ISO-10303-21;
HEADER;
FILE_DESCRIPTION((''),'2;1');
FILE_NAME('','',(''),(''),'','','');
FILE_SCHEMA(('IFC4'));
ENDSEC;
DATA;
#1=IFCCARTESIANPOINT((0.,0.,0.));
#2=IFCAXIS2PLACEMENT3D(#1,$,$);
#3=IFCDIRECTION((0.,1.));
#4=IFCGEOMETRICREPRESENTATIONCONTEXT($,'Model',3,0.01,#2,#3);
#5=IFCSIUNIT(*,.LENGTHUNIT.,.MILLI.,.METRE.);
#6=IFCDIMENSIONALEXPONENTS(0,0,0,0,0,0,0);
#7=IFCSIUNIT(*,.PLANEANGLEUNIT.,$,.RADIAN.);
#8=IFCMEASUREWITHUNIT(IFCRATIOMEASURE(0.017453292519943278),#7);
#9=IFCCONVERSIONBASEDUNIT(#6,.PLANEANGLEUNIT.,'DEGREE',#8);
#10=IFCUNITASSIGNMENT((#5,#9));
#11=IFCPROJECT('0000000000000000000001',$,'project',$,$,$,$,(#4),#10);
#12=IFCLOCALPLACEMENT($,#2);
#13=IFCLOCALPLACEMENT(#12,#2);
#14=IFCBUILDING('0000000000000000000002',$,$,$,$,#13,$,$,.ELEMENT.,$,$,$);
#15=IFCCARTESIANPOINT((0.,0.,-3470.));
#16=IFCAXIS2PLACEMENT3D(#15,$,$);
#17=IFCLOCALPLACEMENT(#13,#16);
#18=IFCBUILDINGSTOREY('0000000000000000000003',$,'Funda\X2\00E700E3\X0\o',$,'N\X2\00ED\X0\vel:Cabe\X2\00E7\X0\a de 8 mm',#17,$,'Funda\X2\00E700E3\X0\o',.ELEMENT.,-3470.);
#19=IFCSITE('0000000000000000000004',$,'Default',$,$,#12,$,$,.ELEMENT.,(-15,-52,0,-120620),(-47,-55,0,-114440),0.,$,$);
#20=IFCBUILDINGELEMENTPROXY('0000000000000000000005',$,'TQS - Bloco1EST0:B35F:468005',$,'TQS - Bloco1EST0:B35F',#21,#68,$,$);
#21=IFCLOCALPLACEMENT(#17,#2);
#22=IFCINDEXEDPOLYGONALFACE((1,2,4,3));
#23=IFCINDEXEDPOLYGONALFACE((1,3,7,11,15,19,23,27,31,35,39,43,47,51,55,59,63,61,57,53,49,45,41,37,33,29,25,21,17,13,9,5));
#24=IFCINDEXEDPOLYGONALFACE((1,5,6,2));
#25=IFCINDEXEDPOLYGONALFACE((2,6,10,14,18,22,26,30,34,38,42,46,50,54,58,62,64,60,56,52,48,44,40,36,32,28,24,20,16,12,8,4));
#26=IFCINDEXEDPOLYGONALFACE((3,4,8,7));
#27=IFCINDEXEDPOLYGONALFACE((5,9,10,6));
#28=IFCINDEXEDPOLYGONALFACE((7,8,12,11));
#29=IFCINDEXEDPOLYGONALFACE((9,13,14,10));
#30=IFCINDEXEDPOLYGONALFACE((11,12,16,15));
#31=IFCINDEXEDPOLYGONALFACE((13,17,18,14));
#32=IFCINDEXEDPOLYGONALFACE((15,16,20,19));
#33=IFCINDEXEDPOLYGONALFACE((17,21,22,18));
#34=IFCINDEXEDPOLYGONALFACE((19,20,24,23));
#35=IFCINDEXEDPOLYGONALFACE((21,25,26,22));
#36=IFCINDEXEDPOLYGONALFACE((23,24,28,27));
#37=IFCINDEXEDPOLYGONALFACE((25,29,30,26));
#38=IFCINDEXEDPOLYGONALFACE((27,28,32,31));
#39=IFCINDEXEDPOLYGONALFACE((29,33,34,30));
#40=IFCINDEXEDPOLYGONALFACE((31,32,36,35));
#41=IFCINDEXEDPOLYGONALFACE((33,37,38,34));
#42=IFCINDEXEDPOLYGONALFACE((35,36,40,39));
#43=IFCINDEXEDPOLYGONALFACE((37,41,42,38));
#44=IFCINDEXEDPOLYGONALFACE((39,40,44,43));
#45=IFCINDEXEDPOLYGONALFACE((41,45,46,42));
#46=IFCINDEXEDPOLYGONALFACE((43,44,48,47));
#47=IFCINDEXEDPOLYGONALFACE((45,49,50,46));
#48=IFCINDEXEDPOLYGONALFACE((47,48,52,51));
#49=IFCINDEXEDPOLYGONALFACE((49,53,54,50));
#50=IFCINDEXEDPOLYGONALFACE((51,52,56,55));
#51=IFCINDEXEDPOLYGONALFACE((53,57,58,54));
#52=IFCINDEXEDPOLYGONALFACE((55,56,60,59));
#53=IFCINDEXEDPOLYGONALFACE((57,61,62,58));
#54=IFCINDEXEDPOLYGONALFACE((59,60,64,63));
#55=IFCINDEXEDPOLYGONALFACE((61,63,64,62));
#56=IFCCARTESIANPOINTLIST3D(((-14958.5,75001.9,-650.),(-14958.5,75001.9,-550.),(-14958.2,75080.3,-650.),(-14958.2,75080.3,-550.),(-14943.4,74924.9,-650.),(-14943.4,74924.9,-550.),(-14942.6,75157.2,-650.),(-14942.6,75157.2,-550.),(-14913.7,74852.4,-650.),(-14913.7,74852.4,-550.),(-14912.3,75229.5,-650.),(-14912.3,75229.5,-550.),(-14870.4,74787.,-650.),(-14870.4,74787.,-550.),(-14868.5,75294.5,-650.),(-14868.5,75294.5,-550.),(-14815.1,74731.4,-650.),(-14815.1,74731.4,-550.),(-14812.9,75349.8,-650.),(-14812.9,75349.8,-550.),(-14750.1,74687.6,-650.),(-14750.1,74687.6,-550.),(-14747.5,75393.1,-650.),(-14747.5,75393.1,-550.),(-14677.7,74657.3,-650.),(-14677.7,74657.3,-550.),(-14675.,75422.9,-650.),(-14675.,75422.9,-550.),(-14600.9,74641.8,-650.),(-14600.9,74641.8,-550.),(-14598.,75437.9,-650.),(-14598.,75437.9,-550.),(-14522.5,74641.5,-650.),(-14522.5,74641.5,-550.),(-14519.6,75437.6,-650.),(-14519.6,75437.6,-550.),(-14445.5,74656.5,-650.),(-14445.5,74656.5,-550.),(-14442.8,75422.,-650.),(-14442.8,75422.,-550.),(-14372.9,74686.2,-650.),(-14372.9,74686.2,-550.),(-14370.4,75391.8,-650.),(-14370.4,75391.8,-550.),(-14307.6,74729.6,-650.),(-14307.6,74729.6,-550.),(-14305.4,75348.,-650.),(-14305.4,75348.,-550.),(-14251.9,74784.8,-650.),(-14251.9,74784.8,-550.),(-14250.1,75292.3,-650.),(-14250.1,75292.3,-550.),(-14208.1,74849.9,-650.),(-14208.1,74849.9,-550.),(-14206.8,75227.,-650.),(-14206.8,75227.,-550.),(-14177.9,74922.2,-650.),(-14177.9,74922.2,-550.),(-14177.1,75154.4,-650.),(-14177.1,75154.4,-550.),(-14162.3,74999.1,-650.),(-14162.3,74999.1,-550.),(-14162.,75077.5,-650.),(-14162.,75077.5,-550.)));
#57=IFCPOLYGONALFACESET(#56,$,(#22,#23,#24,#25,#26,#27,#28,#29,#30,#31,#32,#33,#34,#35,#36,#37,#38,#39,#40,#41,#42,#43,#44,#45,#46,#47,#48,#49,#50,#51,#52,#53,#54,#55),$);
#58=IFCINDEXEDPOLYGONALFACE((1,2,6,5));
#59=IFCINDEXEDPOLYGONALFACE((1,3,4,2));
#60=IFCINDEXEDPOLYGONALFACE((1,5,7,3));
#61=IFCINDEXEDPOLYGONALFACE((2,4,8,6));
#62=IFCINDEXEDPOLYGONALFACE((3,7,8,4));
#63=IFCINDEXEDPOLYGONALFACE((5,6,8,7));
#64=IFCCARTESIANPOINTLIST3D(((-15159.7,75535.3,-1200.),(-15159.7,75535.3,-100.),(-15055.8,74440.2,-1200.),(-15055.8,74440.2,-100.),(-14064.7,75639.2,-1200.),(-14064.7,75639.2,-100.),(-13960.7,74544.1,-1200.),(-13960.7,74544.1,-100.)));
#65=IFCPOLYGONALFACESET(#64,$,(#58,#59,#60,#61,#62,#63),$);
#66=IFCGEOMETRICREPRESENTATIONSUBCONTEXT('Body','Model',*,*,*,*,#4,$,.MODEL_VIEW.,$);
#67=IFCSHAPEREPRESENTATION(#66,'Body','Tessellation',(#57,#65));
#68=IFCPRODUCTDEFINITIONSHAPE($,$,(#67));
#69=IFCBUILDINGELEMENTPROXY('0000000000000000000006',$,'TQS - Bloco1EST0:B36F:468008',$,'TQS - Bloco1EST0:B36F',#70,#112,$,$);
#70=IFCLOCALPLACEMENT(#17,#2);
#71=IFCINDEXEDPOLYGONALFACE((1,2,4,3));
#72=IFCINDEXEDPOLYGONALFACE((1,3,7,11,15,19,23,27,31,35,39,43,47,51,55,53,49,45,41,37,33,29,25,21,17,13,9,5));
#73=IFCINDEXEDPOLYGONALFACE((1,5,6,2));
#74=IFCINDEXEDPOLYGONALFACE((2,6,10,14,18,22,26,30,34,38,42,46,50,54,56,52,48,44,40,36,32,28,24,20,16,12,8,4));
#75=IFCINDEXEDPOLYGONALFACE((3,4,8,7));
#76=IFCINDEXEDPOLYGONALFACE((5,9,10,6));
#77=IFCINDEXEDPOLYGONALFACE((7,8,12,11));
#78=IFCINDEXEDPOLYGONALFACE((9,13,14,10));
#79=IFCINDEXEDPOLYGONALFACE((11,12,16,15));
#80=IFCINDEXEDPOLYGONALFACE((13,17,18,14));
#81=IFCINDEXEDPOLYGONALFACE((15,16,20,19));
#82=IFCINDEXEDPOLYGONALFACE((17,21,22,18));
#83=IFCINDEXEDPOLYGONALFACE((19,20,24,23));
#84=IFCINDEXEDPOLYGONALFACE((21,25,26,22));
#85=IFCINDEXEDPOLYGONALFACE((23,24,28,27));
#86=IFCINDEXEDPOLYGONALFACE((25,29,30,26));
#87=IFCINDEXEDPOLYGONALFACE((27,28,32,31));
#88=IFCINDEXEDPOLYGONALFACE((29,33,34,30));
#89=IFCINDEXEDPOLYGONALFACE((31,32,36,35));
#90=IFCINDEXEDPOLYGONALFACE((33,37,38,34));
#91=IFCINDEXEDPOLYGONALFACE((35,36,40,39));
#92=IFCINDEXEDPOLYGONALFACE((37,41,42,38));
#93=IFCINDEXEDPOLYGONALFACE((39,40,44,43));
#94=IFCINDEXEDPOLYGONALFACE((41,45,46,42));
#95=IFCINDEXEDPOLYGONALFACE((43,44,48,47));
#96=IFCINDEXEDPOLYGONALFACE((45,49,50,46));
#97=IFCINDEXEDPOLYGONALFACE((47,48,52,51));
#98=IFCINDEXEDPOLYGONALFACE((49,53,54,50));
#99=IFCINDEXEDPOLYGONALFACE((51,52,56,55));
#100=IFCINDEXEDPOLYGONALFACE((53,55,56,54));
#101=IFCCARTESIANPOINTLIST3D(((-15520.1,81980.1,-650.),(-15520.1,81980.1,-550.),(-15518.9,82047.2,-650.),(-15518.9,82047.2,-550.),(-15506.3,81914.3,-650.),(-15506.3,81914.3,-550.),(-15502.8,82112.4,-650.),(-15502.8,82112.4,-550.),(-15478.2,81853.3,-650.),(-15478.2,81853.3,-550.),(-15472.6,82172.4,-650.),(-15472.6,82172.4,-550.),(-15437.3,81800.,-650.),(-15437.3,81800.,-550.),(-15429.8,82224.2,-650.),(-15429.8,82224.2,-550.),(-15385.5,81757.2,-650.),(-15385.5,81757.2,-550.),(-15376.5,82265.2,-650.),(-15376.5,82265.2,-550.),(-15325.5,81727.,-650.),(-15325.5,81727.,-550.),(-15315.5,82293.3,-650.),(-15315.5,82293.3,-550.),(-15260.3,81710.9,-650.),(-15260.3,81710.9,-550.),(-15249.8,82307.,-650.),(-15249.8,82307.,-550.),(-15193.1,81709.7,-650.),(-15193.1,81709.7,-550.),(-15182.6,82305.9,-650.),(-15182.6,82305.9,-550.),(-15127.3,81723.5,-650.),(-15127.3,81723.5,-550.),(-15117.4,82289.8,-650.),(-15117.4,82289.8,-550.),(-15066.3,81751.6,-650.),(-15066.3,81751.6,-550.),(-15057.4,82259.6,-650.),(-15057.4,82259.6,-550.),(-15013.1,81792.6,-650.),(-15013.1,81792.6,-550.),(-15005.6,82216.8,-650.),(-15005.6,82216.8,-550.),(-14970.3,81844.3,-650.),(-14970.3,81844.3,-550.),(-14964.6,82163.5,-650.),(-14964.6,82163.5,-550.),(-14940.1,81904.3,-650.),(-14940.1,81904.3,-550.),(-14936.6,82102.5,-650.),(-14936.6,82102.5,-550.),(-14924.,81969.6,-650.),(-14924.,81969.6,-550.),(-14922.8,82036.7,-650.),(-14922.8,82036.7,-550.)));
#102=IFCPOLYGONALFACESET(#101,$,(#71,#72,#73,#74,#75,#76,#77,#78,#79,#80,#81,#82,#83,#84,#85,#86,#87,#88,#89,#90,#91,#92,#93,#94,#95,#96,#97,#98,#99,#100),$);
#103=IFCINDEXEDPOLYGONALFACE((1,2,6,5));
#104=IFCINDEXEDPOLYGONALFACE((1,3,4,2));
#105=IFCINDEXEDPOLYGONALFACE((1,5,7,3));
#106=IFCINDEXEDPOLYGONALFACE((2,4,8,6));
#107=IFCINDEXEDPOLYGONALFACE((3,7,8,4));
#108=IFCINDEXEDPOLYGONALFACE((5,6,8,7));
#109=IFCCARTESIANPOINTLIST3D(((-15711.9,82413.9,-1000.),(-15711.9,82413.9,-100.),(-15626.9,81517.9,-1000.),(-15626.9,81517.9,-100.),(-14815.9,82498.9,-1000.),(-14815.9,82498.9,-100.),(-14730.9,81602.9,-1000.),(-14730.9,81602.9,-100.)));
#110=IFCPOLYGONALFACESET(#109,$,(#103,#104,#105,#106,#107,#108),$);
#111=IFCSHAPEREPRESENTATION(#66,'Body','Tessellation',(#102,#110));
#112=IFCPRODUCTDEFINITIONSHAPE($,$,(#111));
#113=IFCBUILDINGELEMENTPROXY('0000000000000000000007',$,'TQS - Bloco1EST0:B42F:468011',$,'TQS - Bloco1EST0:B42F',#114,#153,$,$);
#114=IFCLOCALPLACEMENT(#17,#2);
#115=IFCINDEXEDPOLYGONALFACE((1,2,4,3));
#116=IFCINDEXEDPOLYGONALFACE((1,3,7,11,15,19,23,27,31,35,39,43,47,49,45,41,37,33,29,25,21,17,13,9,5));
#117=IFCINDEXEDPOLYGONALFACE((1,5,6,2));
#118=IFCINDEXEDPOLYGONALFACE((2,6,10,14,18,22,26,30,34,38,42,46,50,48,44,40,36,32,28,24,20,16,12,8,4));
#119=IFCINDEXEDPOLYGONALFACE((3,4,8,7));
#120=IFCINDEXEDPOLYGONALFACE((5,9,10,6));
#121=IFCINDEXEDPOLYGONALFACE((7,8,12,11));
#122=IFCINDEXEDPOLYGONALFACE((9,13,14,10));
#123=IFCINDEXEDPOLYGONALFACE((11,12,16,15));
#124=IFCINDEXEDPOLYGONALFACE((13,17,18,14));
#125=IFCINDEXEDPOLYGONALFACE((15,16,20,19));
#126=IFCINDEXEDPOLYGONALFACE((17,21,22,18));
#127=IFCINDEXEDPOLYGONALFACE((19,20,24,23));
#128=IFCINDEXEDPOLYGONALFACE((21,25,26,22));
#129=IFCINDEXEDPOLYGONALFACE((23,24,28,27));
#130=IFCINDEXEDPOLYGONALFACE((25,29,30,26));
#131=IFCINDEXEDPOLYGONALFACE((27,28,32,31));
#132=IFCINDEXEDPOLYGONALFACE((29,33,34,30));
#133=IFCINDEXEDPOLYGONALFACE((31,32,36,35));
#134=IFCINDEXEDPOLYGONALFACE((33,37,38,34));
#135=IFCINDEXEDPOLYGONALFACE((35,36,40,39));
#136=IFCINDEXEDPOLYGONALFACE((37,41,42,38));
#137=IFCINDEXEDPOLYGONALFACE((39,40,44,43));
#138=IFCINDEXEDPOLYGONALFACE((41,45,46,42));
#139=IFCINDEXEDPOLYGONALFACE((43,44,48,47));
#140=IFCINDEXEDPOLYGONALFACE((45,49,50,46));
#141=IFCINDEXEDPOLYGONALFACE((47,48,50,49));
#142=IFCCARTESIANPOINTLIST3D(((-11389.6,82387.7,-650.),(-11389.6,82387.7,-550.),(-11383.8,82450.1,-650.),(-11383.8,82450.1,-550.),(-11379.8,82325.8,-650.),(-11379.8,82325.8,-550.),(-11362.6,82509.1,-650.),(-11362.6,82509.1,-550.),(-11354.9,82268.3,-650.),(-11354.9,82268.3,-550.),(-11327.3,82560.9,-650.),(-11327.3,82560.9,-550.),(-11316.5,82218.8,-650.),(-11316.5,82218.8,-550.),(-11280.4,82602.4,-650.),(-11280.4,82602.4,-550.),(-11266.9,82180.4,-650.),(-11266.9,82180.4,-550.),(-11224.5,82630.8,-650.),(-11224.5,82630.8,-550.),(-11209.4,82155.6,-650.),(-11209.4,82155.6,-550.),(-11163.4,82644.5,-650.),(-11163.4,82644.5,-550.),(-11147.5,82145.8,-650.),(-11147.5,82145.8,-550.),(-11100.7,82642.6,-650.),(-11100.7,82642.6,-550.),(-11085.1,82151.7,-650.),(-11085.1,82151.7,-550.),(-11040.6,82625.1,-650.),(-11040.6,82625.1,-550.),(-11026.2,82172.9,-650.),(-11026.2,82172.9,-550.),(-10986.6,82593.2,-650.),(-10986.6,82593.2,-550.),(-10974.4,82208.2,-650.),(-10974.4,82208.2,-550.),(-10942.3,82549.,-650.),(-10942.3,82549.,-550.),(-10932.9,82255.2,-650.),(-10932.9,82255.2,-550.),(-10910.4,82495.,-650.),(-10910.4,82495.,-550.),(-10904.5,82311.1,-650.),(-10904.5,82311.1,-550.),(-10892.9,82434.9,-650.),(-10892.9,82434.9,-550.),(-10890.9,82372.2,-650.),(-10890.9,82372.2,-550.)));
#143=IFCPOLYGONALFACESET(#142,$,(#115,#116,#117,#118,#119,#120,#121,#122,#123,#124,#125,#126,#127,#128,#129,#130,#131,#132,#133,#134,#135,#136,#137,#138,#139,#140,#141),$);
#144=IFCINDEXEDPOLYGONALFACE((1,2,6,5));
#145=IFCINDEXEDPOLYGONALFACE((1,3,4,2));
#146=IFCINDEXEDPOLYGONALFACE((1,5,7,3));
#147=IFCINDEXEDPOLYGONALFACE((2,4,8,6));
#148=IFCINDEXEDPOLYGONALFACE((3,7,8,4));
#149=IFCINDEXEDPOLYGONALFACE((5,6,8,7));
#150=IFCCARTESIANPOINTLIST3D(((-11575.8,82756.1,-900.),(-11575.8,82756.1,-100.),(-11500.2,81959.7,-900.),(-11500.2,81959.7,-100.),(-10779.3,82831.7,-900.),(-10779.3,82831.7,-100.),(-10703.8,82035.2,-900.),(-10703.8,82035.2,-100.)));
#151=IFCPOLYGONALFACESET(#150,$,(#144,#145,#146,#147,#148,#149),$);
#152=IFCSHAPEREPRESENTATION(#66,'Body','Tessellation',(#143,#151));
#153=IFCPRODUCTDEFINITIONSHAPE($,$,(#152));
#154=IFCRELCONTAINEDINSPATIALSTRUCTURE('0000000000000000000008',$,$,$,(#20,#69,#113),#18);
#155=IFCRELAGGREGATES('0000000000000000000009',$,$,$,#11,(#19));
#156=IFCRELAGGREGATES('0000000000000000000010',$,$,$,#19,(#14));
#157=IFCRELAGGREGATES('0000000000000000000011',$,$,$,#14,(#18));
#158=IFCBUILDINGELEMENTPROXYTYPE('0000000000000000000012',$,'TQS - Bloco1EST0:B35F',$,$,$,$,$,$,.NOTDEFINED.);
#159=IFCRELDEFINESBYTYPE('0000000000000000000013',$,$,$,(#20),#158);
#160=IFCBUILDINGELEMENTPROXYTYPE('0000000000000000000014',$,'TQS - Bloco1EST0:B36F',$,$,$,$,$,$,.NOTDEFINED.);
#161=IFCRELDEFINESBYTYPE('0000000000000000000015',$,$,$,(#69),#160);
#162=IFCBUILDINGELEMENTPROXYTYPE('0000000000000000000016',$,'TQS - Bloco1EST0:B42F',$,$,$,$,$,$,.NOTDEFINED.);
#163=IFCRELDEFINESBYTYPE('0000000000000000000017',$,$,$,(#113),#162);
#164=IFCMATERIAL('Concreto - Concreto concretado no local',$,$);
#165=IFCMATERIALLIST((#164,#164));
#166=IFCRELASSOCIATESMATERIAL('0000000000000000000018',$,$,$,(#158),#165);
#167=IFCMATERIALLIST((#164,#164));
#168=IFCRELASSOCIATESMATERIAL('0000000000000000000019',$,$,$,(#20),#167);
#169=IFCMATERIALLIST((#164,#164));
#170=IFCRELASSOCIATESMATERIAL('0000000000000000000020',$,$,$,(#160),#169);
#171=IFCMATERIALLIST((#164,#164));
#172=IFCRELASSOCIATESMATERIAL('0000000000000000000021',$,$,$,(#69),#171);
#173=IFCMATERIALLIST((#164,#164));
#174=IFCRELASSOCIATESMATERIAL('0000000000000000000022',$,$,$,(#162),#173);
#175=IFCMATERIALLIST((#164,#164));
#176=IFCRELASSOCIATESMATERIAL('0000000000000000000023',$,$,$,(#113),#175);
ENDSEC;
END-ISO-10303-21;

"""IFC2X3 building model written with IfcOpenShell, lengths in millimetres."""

from ifc_helpers import new_model, entity, si_unit, converted_unit, direction, frame, frame_2d, origin, origin_2d_with_axis, place, context, subcontext, project, spatial, rectangle, circle, extrude, source, transform, mapped, material, material_list, type_object, type_shapes, element, save


model = new_model("IFC2X3")

# Units and contexts
model_context = context("Model", 3, precision=0.01, world=origin(), true_north=direction((0.0, 1.0)))
body_context = subcontext(model_context, "Body", "Model", "MODEL_VIEW")
ifc_project = project(units=[si_unit("LENGTHUNIT", "METRE", prefix="MILLI"), converted_unit("PLANEANGLEUNIT", "DEGREE", entity("IfcRatioMeasure", 0.017453292519943278), si_unit("PLANEANGLEUNIT", "RADIAN"), dimensions=[0, 0, 0, 0, 0, 0, 0])], contexts=[model_context])

# Site, building, storey
site_placement = place(None, origin())
site = spatial("IfcSite", under=ifc_project, at=site_placement, Name="Default", CompositionType="ELEMENT", RefLatitude=(-15, -52, 0, -120620), RefLongitude=(-47, -55, 0, -114440), RefElevation=0.0)
building_placement = place(site_placement, origin())
building = spatial("IfcBuilding", under=site, at=building_placement, CompositionType="ELEMENT")
storey_placement = place(building_placement, frame((0.0, 0.0, -3470.0)))
storey = spatial("IfcBuildingStorey", under=building, at=storey_placement, Name="Fundação", ObjectType="Nível:Cabeça de 8 mm", LongName="Fundação", CompositionType="ELEMENT", Elevation=-3470.0)

# Building element proxies
ifc_material_1 = material(Name="Concreto - Concreto concretado no local")
ifc_material_list_1 = material_list([ifc_material_1, ifc_material_1])
ifc_material_list_2 = material_list([ifc_material_1, ifc_material_1])
building_element_proxy_type_1 = type_object("IfcBuildingElementProxyType", Name="TQS - Bloco1EST0:B35F", PredefinedType="NOTDEFINED", material=ifc_material_list_2)
shared_shape_1 = source(origin(), body_context, "Body", "SweptSolid", [
    extrude(circle(Radius=400.0, at=frame_2d((0.0, 0.0), x_axis=(1.0, 0.0))), frame((0.0, 0.0, -550.0)), (0.0, 0.0, 1.0), 100.0),
    extrude(rectangle(XDim=1100.0, YDim=1100.0, at=origin_2d_with_axis()), frame((0.0, 0.0, -1100.0), z_axis=(0.0, 0.0, 1.0), x_axis=(-1.0, 0.0, 0.0)), (0.0, 0.0, 1.0), 1100.0),
])
type_shapes(building_element_proxy_type_1, [shared_shape_1])
proxy_1_placement = place(storey_placement, frame((-14560.2, 75039.7, -100.0), z_axis=(0.0, 0.0, 1.0), x_axis=(-0.094456, 0.995529, 0.0)))
element("IfcBuildingElementProxy", 1, at=proxy_1_placement, inside=storey, type_object=building_element_proxy_type_1, material=ifc_material_list_1, Name="TQS - Bloco1EST0:B35F:468005", ObjectType="TQS - Bloco1EST0:B35F", context=body_context, shape_type="MappedRepresentation", body=[
    mapped(shared_shape_1, transform((0.0, 0.0, 0.0), scale=1.0)),
])
ifc_material_list_3 = material_list([ifc_material_1, ifc_material_1])
ifc_material_list_4 = material_list([ifc_material_1, ifc_material_1])
building_element_proxy_type_2 = type_object("IfcBuildingElementProxyType", Name="TQS - Bloco1EST0:B36F", PredefinedType="NOTDEFINED", material=ifc_material_list_4)
shared_shape_2 = source(origin(), body_context, "Body", "SweptSolid", [
    extrude(circle(Radius=300.0, at=frame_2d((0.0, 0.0), x_axis=(1.0, 0.0))), frame((0.0, 0.0, -550.0)), (0.0, 0.0, 1.0), 100.0),
    extrude(rectangle(XDim=900.0, YDim=900.0, at=origin_2d_with_axis()), frame((0.0, 0.0, -900.0), z_axis=(0.0, 0.0, 1.0), x_axis=(-1.0, 0.0, 0.0)), (0.0, 0.0, 1.0), 900.0),
])
type_shapes(building_element_proxy_type_2, [shared_shape_2])
proxy_2_placement = place(storey_placement, frame((-15221.4, 82008.4, -100.0), z_axis=(0.0, 0.0, 1.0), x_axis=(-0.094456, 0.995529, 0.0)))
element("IfcBuildingElementProxy", 2, at=proxy_2_placement, inside=storey, type_object=building_element_proxy_type_2, material=ifc_material_list_3, Name="TQS - Bloco1EST0:B36F:468008", ObjectType="TQS - Bloco1EST0:B36F", context=body_context, shape_type="MappedRepresentation", body=[
    mapped(shared_shape_2, transform((0.0, 0.0, 0.0), scale=1.0)),
])
ifc_material_list_5 = material_list([ifc_material_1, ifc_material_1])
ifc_material_list_6 = material_list([ifc_material_1, ifc_material_1])
building_element_proxy_type_3 = type_object("IfcBuildingElementProxyType", Name="TQS - Bloco1EST0:B42F", PredefinedType="NOTDEFINED", material=ifc_material_list_6)
shared_shape_3 = source(origin(), body_context, "Body", "SweptSolid", [
    extrude(circle(Radius=250.0, at=frame_2d((0.0, 0.0), x_axis=(1.0, 0.0))), frame((0.0, 0.0, -550.0)), (0.0, 0.0, 1.0), 100.0),
    extrude(rectangle(XDim=800.0, YDim=800.0, at=origin_2d_with_axis()), frame((0.0, 0.0, -800.0), z_axis=(0.0, 0.0, 1.0), x_axis=(-1.0, 0.0, 0.0)), (0.0, 0.0, 1.0), 800.0),
])
type_shapes(building_element_proxy_type_3, [shared_shape_3])
proxy_3_placement = place(storey_placement, frame((-11139.8, 82395.7, -100.0), z_axis=(0.0, 0.0, 1.0), x_axis=(-0.094456, 0.995529, 0.0)))
element("IfcBuildingElementProxy", 3, at=proxy_3_placement, inside=storey, type_object=building_element_proxy_type_3, material=ifc_material_list_5, Name="TQS - Bloco1EST0:B42F:468011", ObjectType="TQS - Bloco1EST0:B42F", context=body_context, shape_type="MappedRepresentation", body=[
    mapped(shared_shape_3, transform((0.0, 0.0, 0.0), scale=1.0)),
])

save(model, "model.ifc")
